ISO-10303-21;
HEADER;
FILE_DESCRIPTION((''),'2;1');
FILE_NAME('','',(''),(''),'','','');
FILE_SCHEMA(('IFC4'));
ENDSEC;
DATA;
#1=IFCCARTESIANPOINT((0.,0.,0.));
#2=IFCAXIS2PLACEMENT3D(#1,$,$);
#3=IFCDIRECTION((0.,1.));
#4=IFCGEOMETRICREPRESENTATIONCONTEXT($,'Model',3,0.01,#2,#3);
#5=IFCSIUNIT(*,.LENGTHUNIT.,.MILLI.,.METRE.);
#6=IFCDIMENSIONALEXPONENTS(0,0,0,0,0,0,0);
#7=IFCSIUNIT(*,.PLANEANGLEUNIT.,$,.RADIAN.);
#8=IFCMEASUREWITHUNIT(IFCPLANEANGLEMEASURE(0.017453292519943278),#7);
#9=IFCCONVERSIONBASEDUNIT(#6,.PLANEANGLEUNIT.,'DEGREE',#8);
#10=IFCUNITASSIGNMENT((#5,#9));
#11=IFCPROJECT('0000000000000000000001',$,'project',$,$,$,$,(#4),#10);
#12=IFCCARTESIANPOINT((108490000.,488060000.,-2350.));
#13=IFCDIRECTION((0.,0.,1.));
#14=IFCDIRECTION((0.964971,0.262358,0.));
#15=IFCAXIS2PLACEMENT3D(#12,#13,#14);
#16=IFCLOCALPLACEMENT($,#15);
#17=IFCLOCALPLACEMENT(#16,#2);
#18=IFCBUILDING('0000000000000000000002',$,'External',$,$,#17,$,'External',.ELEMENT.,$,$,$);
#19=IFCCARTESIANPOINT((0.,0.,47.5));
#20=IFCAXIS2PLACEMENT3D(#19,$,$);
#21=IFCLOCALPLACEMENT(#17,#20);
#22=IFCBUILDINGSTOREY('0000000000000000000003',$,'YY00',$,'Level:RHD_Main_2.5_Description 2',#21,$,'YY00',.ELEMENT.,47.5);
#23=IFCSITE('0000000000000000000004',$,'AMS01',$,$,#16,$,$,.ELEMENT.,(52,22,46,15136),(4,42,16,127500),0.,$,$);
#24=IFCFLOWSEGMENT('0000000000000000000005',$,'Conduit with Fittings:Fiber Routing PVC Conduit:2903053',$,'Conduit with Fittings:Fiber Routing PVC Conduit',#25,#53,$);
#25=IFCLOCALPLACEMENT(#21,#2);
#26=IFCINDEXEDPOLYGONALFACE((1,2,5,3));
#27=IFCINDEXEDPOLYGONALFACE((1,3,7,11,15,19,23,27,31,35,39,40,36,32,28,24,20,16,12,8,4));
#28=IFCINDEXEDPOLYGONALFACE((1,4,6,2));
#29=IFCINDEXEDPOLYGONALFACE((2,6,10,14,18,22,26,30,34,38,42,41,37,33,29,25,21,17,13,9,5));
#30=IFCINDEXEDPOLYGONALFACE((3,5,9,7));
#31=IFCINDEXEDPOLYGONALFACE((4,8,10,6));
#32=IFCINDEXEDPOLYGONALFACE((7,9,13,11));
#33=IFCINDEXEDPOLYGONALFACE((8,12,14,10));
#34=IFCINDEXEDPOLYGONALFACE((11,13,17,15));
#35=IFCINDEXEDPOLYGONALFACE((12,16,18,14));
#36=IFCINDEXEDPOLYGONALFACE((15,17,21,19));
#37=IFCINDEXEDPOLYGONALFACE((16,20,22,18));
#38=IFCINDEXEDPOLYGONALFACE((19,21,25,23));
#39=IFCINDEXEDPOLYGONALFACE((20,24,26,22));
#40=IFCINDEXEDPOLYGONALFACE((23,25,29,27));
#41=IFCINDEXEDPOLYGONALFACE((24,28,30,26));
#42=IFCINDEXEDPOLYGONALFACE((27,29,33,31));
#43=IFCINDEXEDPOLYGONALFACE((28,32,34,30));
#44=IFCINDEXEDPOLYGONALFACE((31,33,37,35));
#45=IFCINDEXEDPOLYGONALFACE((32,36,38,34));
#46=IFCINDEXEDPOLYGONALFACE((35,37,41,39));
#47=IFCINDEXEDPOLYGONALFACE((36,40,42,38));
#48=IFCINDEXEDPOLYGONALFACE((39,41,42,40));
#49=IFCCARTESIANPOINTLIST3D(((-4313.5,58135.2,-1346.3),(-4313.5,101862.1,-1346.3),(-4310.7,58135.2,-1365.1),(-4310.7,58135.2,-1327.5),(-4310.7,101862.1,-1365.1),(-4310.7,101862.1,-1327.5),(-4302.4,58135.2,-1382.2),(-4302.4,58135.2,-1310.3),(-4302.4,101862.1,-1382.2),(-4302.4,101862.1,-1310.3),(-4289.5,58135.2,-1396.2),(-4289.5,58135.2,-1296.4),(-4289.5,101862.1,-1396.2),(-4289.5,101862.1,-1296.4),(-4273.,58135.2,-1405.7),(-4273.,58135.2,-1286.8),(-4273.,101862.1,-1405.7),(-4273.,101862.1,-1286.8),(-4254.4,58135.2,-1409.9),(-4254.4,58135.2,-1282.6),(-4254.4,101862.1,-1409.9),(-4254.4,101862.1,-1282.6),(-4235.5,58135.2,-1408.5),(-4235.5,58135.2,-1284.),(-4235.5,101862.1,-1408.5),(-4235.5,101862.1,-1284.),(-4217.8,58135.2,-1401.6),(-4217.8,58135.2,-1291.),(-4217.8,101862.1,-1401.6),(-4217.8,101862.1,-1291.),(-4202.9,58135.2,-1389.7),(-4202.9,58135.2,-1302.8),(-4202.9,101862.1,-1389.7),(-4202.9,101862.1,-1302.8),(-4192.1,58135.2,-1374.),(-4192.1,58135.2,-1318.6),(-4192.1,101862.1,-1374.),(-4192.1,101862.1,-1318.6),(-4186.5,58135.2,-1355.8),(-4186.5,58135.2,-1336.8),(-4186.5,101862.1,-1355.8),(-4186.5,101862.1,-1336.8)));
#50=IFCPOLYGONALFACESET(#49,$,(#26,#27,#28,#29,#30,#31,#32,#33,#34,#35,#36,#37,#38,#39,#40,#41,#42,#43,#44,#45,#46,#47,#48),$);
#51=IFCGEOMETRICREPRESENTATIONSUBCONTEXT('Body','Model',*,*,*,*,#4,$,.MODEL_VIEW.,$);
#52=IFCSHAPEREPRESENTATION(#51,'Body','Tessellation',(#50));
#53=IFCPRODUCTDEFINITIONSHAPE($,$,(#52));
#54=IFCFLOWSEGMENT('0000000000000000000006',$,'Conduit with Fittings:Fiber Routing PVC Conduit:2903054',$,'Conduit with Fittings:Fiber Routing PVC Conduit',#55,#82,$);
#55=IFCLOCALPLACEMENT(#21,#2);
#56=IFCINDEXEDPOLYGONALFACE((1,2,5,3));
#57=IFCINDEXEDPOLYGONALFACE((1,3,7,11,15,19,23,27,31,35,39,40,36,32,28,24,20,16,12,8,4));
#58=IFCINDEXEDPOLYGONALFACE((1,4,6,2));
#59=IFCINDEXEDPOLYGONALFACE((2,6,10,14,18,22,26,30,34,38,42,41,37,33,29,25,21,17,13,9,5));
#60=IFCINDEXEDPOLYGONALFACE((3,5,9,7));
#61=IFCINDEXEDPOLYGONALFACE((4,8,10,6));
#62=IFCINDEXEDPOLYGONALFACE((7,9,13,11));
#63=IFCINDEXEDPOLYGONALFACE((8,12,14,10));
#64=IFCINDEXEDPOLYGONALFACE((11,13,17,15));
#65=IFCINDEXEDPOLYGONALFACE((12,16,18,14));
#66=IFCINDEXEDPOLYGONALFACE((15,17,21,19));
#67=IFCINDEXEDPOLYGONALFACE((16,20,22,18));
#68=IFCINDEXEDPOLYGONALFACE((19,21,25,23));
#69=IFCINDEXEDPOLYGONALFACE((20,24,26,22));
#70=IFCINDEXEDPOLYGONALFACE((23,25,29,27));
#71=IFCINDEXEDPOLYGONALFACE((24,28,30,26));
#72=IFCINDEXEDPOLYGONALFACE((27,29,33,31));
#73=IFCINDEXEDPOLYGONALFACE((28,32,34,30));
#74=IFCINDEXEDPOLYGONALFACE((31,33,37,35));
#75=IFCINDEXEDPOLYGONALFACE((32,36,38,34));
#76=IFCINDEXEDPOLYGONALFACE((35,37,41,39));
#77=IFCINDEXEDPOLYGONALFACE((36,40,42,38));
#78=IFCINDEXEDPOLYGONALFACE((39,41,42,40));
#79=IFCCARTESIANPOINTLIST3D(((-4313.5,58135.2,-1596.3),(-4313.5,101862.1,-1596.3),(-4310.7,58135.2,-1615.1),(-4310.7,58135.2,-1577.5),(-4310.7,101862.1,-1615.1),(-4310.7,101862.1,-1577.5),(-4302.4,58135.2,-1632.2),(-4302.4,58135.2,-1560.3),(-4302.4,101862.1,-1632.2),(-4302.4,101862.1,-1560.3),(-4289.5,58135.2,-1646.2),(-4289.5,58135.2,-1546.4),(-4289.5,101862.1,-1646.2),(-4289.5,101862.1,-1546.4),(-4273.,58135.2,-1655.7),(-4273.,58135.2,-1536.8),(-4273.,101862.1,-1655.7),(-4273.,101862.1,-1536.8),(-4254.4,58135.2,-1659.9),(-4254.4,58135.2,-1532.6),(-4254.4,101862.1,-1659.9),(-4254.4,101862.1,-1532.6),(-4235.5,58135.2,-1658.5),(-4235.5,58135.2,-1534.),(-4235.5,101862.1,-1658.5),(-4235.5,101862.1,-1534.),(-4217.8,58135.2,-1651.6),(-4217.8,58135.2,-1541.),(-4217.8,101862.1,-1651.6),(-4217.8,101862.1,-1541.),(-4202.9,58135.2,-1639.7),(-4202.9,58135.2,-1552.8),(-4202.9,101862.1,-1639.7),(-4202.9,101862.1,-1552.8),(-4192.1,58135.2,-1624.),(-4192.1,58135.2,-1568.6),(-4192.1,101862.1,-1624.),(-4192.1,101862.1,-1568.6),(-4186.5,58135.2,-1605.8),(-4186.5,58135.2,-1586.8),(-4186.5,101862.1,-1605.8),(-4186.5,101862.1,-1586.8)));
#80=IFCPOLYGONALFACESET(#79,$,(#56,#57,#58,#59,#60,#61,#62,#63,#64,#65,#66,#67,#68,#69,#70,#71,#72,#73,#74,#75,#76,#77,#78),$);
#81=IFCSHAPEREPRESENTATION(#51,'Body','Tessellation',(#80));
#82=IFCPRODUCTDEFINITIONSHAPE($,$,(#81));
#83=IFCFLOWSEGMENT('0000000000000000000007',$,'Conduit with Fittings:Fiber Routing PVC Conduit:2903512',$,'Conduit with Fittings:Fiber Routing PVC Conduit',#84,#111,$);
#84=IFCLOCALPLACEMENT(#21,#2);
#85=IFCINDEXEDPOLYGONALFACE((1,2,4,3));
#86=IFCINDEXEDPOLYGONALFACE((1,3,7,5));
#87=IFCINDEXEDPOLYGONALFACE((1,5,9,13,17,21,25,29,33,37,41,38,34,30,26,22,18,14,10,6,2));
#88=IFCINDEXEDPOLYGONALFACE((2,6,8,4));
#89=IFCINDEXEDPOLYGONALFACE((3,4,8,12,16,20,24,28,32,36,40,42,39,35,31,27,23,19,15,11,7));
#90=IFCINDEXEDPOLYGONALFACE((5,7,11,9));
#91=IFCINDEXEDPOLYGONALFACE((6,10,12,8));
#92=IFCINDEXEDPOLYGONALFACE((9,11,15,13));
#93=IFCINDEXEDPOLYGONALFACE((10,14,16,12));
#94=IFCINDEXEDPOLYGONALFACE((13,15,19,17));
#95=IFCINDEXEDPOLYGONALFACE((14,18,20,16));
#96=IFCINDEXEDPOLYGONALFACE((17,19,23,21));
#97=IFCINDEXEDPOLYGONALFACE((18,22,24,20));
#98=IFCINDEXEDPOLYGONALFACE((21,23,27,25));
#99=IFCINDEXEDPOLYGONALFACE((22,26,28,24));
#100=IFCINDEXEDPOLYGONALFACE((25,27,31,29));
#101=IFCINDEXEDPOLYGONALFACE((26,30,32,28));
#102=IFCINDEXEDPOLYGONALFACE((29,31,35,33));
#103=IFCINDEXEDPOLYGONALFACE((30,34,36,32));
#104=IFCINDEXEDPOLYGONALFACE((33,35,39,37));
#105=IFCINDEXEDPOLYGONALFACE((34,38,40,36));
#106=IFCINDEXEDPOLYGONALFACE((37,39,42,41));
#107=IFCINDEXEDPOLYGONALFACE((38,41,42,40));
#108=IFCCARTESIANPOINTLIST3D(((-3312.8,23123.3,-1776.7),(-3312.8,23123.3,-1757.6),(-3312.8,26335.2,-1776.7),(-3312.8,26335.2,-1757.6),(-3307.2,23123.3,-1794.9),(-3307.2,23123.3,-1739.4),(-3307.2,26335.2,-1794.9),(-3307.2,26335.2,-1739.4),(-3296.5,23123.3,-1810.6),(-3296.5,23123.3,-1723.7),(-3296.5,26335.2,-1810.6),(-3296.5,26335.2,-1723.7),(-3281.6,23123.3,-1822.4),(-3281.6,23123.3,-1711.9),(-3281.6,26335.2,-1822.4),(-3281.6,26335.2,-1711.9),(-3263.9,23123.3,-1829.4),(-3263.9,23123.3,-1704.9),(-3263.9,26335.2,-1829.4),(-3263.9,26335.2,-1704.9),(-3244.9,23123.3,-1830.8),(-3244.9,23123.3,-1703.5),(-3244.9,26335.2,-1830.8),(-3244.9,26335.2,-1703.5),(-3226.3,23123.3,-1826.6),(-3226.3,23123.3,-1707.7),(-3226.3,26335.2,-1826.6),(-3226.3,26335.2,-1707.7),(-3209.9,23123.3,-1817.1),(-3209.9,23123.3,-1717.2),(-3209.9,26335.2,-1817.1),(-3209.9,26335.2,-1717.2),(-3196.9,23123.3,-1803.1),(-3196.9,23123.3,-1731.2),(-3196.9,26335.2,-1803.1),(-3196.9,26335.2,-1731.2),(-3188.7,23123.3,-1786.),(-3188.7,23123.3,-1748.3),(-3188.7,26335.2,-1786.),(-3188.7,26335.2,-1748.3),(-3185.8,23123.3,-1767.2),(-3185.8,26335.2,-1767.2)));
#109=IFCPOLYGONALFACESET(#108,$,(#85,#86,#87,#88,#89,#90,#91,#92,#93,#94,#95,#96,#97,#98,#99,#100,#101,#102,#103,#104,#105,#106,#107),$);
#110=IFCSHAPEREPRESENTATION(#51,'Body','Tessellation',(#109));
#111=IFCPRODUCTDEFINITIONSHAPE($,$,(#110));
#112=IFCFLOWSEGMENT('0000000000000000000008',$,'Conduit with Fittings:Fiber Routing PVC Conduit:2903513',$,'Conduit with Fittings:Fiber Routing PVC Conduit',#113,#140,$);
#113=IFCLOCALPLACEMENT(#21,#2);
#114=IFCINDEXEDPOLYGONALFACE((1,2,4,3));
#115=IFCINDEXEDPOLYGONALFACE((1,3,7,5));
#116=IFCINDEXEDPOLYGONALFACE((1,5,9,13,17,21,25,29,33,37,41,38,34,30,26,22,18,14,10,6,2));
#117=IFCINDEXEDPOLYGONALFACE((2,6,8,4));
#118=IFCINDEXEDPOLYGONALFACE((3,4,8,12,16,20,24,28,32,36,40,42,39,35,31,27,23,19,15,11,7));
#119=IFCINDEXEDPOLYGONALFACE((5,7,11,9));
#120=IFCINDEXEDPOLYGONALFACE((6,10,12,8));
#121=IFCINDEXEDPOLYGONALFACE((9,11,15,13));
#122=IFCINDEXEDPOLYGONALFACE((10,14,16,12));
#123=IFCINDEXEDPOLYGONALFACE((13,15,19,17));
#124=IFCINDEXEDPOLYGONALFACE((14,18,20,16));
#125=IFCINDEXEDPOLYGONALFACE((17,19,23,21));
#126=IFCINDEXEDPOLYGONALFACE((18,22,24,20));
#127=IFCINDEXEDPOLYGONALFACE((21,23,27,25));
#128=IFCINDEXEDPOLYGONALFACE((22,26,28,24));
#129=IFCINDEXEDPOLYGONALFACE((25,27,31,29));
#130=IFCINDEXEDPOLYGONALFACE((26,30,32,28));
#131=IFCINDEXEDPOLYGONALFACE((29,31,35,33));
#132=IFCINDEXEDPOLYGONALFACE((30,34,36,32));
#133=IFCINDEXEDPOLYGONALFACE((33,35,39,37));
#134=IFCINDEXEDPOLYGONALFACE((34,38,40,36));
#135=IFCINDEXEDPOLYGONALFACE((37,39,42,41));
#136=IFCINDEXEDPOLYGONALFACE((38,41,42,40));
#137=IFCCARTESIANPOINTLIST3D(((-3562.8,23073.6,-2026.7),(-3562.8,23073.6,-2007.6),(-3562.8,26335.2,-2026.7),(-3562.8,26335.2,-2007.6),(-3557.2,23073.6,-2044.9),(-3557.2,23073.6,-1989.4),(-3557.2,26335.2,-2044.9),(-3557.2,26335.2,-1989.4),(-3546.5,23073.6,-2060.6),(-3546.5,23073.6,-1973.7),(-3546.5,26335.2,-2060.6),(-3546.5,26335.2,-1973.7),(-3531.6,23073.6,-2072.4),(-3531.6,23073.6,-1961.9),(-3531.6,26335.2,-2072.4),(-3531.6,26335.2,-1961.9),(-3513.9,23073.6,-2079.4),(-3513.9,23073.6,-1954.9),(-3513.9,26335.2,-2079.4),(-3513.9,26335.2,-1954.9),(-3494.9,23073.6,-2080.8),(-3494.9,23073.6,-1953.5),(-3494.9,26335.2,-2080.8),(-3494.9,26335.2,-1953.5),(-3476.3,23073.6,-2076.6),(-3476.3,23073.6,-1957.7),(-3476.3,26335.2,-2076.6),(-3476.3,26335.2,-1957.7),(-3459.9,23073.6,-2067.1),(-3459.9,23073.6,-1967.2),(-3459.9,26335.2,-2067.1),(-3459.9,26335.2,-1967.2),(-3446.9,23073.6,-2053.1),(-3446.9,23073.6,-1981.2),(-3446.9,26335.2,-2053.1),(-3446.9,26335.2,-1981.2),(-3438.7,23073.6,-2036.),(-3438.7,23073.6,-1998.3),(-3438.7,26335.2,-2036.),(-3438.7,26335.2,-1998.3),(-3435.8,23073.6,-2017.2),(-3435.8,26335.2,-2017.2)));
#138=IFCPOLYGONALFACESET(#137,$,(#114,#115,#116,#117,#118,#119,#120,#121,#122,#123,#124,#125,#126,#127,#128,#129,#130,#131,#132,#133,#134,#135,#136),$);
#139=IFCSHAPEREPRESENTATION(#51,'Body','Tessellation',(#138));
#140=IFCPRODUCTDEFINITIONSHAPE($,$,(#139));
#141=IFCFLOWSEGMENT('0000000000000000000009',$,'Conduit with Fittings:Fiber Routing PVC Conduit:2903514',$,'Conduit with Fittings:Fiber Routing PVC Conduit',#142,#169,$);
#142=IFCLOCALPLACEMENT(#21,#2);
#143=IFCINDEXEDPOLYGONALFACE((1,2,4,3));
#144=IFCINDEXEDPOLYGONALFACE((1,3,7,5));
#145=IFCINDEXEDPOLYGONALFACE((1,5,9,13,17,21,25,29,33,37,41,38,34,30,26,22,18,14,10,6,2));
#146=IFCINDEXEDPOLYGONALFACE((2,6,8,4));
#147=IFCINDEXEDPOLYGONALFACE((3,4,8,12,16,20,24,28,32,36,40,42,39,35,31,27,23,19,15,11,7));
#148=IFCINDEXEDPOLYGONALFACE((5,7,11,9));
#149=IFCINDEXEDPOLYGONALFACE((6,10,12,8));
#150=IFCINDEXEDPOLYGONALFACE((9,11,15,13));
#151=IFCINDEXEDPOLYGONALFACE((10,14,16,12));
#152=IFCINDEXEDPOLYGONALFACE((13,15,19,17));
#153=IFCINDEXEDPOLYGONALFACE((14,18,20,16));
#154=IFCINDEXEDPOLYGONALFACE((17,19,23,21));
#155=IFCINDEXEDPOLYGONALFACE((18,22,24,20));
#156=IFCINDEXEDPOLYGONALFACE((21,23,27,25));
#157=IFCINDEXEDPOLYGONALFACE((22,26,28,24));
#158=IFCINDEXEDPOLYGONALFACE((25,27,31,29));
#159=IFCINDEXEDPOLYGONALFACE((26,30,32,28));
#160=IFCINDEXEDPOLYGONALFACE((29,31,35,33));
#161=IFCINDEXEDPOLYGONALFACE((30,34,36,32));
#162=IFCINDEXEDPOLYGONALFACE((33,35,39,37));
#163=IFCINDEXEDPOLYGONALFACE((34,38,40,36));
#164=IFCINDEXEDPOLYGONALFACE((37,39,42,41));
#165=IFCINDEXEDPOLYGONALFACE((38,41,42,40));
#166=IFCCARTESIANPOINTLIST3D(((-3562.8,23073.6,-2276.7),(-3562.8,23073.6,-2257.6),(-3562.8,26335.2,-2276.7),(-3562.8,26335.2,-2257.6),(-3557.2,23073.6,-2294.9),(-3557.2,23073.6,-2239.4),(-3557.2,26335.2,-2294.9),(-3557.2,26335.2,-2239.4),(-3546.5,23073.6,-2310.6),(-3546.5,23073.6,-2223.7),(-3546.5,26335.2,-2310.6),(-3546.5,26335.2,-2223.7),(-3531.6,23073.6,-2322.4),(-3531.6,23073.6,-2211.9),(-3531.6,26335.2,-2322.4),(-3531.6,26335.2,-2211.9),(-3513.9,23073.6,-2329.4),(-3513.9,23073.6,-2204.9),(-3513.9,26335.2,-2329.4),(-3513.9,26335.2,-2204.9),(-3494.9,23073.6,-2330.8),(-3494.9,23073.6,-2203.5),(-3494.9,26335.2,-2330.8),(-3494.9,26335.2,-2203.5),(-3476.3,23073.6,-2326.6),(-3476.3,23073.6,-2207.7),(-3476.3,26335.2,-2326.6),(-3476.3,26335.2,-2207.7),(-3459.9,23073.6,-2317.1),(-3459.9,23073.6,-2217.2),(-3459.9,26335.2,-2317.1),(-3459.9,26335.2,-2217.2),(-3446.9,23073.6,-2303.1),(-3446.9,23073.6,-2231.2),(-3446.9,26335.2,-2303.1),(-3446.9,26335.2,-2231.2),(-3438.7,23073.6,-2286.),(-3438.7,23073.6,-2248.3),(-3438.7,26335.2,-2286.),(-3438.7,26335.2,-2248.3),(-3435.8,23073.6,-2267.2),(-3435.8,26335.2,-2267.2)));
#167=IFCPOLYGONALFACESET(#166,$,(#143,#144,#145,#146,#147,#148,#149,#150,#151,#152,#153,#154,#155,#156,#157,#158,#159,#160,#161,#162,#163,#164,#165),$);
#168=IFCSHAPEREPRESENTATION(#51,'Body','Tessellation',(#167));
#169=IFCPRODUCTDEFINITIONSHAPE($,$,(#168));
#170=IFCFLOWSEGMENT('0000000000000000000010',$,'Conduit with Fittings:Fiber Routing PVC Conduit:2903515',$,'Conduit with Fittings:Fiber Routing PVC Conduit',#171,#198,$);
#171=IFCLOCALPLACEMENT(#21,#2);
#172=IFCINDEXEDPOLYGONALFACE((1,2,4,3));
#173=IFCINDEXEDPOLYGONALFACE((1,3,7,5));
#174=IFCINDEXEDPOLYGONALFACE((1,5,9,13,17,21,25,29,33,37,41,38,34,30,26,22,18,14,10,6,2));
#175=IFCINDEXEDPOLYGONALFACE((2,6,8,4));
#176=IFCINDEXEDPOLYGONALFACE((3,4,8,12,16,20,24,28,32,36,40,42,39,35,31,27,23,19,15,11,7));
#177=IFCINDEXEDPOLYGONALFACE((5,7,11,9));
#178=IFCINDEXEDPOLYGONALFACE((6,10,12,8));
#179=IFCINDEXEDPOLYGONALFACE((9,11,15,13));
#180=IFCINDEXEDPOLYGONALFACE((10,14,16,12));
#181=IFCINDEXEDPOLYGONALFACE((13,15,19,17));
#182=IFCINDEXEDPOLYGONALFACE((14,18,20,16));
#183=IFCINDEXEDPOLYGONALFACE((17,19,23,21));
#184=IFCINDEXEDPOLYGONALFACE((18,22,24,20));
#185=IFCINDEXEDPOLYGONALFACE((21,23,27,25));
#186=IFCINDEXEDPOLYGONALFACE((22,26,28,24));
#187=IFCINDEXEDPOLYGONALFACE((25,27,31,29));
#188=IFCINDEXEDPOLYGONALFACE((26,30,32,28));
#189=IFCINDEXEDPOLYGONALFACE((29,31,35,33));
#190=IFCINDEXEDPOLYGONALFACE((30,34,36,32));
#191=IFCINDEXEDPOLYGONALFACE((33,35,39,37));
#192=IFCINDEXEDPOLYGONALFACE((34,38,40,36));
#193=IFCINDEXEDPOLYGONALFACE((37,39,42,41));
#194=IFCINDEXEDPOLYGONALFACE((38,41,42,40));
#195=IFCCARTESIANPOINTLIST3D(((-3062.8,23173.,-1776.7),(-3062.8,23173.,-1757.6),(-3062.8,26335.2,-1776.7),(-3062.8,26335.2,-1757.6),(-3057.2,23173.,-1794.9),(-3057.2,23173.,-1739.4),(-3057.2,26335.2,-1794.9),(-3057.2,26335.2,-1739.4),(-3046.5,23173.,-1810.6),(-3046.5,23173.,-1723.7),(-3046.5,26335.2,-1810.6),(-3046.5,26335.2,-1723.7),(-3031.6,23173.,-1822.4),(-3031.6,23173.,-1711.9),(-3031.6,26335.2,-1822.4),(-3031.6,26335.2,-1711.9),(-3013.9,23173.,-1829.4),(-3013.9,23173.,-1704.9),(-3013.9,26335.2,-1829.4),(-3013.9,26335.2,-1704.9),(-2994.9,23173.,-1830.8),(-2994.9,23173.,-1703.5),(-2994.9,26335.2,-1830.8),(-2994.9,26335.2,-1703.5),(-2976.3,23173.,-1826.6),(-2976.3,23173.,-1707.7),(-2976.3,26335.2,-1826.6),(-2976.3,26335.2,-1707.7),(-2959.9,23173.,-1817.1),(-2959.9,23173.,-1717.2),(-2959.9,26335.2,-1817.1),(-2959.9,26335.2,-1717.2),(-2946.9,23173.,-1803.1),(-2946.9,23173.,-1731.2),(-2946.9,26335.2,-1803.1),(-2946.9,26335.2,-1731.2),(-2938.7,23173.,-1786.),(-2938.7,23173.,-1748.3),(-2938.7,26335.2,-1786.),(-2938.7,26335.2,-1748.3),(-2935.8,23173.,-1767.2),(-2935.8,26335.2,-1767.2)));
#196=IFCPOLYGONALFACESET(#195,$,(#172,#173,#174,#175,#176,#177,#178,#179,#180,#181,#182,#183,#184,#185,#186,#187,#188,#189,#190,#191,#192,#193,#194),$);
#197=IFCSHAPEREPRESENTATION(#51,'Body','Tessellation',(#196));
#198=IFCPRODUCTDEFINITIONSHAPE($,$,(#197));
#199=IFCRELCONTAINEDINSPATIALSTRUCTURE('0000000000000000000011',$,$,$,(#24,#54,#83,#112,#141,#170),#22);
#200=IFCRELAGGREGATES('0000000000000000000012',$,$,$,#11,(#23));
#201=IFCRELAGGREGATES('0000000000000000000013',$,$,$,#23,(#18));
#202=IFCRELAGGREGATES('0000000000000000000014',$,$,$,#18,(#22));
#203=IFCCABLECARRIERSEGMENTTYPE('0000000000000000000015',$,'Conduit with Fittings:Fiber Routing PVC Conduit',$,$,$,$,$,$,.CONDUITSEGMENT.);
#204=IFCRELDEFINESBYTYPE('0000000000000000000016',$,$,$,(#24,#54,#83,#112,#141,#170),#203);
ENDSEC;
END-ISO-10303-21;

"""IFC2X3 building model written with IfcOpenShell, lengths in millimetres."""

from ifc_helpers import new_model, entity, si_unit, converted_unit, direction, frame, frame_2d, origin, origin_2d_with_axis, place, context, subcontext, project, spatial, circle, extrude, type_object, element, save


model = new_model("IFC2X3")

# Units and contexts
model_context = context("Model", 3, precision=0.01, world=origin(), true_north=direction((0.0, 1.0)))
body_context = subcontext(model_context, "Body", "Model", "MODEL_VIEW")
ifc_project = project(units=[si_unit("LENGTHUNIT", "METRE", prefix="MILLI"), converted_unit("PLANEANGLEUNIT", "DEGREE", entity("IfcPlaneAngleMeasure", 0.017453292519943278), si_unit("PLANEANGLEUNIT", "RADIAN"), dimensions=[0, 0, 0, 0, 0, 0, 0])], contexts=[model_context])

# Site, building, storey
site_placement = place(None, frame((108490000.0, 488060000.0, -2350.0), z_axis=(0.0, 0.0, 1.0), x_axis=(0.964971, 0.262358, 0.0)))
site = spatial("IfcSite", under=ifc_project, at=site_placement, Name="AMS01", CompositionType="ELEMENT", RefLatitude=(52, 22, 46, 15136), RefLongitude=(4, 42, 16, 127500), RefElevation=0.0)
building_placement = place(site_placement, origin())
building = spatial("IfcBuilding", under=site, at=building_placement, Name="External", LongName="External", CompositionType="ELEMENT")
storey_placement = place(building_placement, frame((0.0, 0.0, 47.5)))
storey = spatial("IfcBuildingStorey", under=building, at=storey_placement, Name="YY00", ObjectType="Level:RHD_Main_2.5_Description 2", LongName="YY00", CompositionType="ELEMENT", Elevation=47.5)

# Flow segments
cable_carrier_segment_type = type_object("IfcCableCarrierSegmentType", Name="Conduit with Fittings:Fiber Routing PVC Conduit", PredefinedType="CONDUITSEGMENT")
flow_segment_1_placement = place(storey_placement, origin())
element("IfcFlowSegment", 1, at=flow_segment_1_placement, inside=storey, type_object=cable_carrier_segment_type, Name="Conduit with Fittings:Fiber Routing PVC Conduit:2903053", ObjectType="Conduit with Fittings:Fiber Routing PVC Conduit", context=body_context, shape_type="SweptSolid", body=[
    extrude(circle(Radius=63.9, at=frame_2d((0.0, 0.0), x_axis=(1.0, 0.0))), frame((-4249.7, 58135.2, -1346.3), z_axis=(0.0, 1.0, 0.0), x_axis=(-1.0, 0.0, 0.0)), (0.0, 0.0, 1.0), 43726.9),
])
flow_segment_2_placement = place(storey_placement, origin())
element("IfcFlowSegment", 2, at=flow_segment_2_placement, inside=storey, type_object=cable_carrier_segment_type, Name="Conduit with Fittings:Fiber Routing PVC Conduit:2903054", ObjectType="Conduit with Fittings:Fiber Routing PVC Conduit", context=body_context, shape_type="SweptSolid", body=[
    extrude(circle(Radius=63.9, at=frame_2d((0.0, 0.0), x_axis=(1.0, 0.0))), frame((-4249.7, 58135.2, -1596.3), z_axis=(0.0, 1.0, 0.0), x_axis=(-1.0, 0.0, 0.0)), (0.0, 0.0, 1.0), 43726.9),
])
flow_segment_3_placement = place(storey_placement, origin())
element("IfcFlowSegment", 3, at=flow_segment_3_placement, inside=storey, type_object=cable_carrier_segment_type, Name="Conduit with Fittings:Fiber Routing PVC Conduit:2903512", ObjectType="Conduit with Fittings:Fiber Routing PVC Conduit", context=body_context, shape_type="SweptSolid", body=[
    extrude(circle(Radius=63.9, at=frame_2d((0.0, 0.0), x_axis=(1.0, 0.0))), frame((-3249.7, 23123.3, -1767.2), z_axis=(0.0, 1.0, 0.0), x_axis=(1.0, 0.0, 0.0)), (0.0, 0.0, 1.0), 3211.9),
])
flow_segment_4_placement = place(storey_placement, origin())
element("IfcFlowSegment", 4, at=flow_segment_4_placement, inside=storey, type_object=cable_carrier_segment_type, Name="Conduit with Fittings:Fiber Routing PVC Conduit:2903513", ObjectType="Conduit with Fittings:Fiber Routing PVC Conduit", context=body_context, shape_type="SweptSolid", body=[
    extrude(circle(Radius=63.9, at=frame_2d((0.0, 0.0), x_axis=(1.0, 0.0))), frame((-3499.7, 23073.6, -2017.2), z_axis=(0.0, 1.0, 0.0), x_axis=(1.0, 0.0, 0.0)), (0.0, 0.0, 1.0), 3261.7),
])
flow_segment_5_placement = place(storey_placement, origin())
element("IfcFlowSegment", 5, at=flow_segment_5_placement, inside=storey, type_object=cable_carrier_segment_type, Name="Conduit with Fittings:Fiber Routing PVC Conduit:2903514", ObjectType="Conduit with Fittings:Fiber Routing PVC Conduit", context=body_context, shape_type="SweptSolid", body=[
    extrude(circle(Radius=63.9, at=origin_2d_with_axis()), frame((-3499.7, 23073.6, -2267.2), z_axis=(0.0, 1.0, 0.0), x_axis=(1.0, 0.0, 0.0)), (0.0, 0.0, 1.0), 3261.7),
])
flow_segment_6_placement = place(storey_placement, origin())
element("IfcFlowSegment", 6, at=flow_segment_6_placement, inside=storey, type_object=cable_carrier_segment_type, Name="Conduit with Fittings:Fiber Routing PVC Conduit:2903515", ObjectType="Conduit with Fittings:Fiber Routing PVC Conduit", context=body_context, shape_type="SweptSolid", body=[
    extrude(circle(Radius=63.9, at=origin_2d_with_axis()), frame((-2999.7, 23173.0, -1767.2), z_axis=(0.0, 1.0, 0.0), x_axis=(1.0, 0.0, 0.0)), (0.0, 0.0, 1.0), 3162.2),
])

save(model, "model.ifc")
